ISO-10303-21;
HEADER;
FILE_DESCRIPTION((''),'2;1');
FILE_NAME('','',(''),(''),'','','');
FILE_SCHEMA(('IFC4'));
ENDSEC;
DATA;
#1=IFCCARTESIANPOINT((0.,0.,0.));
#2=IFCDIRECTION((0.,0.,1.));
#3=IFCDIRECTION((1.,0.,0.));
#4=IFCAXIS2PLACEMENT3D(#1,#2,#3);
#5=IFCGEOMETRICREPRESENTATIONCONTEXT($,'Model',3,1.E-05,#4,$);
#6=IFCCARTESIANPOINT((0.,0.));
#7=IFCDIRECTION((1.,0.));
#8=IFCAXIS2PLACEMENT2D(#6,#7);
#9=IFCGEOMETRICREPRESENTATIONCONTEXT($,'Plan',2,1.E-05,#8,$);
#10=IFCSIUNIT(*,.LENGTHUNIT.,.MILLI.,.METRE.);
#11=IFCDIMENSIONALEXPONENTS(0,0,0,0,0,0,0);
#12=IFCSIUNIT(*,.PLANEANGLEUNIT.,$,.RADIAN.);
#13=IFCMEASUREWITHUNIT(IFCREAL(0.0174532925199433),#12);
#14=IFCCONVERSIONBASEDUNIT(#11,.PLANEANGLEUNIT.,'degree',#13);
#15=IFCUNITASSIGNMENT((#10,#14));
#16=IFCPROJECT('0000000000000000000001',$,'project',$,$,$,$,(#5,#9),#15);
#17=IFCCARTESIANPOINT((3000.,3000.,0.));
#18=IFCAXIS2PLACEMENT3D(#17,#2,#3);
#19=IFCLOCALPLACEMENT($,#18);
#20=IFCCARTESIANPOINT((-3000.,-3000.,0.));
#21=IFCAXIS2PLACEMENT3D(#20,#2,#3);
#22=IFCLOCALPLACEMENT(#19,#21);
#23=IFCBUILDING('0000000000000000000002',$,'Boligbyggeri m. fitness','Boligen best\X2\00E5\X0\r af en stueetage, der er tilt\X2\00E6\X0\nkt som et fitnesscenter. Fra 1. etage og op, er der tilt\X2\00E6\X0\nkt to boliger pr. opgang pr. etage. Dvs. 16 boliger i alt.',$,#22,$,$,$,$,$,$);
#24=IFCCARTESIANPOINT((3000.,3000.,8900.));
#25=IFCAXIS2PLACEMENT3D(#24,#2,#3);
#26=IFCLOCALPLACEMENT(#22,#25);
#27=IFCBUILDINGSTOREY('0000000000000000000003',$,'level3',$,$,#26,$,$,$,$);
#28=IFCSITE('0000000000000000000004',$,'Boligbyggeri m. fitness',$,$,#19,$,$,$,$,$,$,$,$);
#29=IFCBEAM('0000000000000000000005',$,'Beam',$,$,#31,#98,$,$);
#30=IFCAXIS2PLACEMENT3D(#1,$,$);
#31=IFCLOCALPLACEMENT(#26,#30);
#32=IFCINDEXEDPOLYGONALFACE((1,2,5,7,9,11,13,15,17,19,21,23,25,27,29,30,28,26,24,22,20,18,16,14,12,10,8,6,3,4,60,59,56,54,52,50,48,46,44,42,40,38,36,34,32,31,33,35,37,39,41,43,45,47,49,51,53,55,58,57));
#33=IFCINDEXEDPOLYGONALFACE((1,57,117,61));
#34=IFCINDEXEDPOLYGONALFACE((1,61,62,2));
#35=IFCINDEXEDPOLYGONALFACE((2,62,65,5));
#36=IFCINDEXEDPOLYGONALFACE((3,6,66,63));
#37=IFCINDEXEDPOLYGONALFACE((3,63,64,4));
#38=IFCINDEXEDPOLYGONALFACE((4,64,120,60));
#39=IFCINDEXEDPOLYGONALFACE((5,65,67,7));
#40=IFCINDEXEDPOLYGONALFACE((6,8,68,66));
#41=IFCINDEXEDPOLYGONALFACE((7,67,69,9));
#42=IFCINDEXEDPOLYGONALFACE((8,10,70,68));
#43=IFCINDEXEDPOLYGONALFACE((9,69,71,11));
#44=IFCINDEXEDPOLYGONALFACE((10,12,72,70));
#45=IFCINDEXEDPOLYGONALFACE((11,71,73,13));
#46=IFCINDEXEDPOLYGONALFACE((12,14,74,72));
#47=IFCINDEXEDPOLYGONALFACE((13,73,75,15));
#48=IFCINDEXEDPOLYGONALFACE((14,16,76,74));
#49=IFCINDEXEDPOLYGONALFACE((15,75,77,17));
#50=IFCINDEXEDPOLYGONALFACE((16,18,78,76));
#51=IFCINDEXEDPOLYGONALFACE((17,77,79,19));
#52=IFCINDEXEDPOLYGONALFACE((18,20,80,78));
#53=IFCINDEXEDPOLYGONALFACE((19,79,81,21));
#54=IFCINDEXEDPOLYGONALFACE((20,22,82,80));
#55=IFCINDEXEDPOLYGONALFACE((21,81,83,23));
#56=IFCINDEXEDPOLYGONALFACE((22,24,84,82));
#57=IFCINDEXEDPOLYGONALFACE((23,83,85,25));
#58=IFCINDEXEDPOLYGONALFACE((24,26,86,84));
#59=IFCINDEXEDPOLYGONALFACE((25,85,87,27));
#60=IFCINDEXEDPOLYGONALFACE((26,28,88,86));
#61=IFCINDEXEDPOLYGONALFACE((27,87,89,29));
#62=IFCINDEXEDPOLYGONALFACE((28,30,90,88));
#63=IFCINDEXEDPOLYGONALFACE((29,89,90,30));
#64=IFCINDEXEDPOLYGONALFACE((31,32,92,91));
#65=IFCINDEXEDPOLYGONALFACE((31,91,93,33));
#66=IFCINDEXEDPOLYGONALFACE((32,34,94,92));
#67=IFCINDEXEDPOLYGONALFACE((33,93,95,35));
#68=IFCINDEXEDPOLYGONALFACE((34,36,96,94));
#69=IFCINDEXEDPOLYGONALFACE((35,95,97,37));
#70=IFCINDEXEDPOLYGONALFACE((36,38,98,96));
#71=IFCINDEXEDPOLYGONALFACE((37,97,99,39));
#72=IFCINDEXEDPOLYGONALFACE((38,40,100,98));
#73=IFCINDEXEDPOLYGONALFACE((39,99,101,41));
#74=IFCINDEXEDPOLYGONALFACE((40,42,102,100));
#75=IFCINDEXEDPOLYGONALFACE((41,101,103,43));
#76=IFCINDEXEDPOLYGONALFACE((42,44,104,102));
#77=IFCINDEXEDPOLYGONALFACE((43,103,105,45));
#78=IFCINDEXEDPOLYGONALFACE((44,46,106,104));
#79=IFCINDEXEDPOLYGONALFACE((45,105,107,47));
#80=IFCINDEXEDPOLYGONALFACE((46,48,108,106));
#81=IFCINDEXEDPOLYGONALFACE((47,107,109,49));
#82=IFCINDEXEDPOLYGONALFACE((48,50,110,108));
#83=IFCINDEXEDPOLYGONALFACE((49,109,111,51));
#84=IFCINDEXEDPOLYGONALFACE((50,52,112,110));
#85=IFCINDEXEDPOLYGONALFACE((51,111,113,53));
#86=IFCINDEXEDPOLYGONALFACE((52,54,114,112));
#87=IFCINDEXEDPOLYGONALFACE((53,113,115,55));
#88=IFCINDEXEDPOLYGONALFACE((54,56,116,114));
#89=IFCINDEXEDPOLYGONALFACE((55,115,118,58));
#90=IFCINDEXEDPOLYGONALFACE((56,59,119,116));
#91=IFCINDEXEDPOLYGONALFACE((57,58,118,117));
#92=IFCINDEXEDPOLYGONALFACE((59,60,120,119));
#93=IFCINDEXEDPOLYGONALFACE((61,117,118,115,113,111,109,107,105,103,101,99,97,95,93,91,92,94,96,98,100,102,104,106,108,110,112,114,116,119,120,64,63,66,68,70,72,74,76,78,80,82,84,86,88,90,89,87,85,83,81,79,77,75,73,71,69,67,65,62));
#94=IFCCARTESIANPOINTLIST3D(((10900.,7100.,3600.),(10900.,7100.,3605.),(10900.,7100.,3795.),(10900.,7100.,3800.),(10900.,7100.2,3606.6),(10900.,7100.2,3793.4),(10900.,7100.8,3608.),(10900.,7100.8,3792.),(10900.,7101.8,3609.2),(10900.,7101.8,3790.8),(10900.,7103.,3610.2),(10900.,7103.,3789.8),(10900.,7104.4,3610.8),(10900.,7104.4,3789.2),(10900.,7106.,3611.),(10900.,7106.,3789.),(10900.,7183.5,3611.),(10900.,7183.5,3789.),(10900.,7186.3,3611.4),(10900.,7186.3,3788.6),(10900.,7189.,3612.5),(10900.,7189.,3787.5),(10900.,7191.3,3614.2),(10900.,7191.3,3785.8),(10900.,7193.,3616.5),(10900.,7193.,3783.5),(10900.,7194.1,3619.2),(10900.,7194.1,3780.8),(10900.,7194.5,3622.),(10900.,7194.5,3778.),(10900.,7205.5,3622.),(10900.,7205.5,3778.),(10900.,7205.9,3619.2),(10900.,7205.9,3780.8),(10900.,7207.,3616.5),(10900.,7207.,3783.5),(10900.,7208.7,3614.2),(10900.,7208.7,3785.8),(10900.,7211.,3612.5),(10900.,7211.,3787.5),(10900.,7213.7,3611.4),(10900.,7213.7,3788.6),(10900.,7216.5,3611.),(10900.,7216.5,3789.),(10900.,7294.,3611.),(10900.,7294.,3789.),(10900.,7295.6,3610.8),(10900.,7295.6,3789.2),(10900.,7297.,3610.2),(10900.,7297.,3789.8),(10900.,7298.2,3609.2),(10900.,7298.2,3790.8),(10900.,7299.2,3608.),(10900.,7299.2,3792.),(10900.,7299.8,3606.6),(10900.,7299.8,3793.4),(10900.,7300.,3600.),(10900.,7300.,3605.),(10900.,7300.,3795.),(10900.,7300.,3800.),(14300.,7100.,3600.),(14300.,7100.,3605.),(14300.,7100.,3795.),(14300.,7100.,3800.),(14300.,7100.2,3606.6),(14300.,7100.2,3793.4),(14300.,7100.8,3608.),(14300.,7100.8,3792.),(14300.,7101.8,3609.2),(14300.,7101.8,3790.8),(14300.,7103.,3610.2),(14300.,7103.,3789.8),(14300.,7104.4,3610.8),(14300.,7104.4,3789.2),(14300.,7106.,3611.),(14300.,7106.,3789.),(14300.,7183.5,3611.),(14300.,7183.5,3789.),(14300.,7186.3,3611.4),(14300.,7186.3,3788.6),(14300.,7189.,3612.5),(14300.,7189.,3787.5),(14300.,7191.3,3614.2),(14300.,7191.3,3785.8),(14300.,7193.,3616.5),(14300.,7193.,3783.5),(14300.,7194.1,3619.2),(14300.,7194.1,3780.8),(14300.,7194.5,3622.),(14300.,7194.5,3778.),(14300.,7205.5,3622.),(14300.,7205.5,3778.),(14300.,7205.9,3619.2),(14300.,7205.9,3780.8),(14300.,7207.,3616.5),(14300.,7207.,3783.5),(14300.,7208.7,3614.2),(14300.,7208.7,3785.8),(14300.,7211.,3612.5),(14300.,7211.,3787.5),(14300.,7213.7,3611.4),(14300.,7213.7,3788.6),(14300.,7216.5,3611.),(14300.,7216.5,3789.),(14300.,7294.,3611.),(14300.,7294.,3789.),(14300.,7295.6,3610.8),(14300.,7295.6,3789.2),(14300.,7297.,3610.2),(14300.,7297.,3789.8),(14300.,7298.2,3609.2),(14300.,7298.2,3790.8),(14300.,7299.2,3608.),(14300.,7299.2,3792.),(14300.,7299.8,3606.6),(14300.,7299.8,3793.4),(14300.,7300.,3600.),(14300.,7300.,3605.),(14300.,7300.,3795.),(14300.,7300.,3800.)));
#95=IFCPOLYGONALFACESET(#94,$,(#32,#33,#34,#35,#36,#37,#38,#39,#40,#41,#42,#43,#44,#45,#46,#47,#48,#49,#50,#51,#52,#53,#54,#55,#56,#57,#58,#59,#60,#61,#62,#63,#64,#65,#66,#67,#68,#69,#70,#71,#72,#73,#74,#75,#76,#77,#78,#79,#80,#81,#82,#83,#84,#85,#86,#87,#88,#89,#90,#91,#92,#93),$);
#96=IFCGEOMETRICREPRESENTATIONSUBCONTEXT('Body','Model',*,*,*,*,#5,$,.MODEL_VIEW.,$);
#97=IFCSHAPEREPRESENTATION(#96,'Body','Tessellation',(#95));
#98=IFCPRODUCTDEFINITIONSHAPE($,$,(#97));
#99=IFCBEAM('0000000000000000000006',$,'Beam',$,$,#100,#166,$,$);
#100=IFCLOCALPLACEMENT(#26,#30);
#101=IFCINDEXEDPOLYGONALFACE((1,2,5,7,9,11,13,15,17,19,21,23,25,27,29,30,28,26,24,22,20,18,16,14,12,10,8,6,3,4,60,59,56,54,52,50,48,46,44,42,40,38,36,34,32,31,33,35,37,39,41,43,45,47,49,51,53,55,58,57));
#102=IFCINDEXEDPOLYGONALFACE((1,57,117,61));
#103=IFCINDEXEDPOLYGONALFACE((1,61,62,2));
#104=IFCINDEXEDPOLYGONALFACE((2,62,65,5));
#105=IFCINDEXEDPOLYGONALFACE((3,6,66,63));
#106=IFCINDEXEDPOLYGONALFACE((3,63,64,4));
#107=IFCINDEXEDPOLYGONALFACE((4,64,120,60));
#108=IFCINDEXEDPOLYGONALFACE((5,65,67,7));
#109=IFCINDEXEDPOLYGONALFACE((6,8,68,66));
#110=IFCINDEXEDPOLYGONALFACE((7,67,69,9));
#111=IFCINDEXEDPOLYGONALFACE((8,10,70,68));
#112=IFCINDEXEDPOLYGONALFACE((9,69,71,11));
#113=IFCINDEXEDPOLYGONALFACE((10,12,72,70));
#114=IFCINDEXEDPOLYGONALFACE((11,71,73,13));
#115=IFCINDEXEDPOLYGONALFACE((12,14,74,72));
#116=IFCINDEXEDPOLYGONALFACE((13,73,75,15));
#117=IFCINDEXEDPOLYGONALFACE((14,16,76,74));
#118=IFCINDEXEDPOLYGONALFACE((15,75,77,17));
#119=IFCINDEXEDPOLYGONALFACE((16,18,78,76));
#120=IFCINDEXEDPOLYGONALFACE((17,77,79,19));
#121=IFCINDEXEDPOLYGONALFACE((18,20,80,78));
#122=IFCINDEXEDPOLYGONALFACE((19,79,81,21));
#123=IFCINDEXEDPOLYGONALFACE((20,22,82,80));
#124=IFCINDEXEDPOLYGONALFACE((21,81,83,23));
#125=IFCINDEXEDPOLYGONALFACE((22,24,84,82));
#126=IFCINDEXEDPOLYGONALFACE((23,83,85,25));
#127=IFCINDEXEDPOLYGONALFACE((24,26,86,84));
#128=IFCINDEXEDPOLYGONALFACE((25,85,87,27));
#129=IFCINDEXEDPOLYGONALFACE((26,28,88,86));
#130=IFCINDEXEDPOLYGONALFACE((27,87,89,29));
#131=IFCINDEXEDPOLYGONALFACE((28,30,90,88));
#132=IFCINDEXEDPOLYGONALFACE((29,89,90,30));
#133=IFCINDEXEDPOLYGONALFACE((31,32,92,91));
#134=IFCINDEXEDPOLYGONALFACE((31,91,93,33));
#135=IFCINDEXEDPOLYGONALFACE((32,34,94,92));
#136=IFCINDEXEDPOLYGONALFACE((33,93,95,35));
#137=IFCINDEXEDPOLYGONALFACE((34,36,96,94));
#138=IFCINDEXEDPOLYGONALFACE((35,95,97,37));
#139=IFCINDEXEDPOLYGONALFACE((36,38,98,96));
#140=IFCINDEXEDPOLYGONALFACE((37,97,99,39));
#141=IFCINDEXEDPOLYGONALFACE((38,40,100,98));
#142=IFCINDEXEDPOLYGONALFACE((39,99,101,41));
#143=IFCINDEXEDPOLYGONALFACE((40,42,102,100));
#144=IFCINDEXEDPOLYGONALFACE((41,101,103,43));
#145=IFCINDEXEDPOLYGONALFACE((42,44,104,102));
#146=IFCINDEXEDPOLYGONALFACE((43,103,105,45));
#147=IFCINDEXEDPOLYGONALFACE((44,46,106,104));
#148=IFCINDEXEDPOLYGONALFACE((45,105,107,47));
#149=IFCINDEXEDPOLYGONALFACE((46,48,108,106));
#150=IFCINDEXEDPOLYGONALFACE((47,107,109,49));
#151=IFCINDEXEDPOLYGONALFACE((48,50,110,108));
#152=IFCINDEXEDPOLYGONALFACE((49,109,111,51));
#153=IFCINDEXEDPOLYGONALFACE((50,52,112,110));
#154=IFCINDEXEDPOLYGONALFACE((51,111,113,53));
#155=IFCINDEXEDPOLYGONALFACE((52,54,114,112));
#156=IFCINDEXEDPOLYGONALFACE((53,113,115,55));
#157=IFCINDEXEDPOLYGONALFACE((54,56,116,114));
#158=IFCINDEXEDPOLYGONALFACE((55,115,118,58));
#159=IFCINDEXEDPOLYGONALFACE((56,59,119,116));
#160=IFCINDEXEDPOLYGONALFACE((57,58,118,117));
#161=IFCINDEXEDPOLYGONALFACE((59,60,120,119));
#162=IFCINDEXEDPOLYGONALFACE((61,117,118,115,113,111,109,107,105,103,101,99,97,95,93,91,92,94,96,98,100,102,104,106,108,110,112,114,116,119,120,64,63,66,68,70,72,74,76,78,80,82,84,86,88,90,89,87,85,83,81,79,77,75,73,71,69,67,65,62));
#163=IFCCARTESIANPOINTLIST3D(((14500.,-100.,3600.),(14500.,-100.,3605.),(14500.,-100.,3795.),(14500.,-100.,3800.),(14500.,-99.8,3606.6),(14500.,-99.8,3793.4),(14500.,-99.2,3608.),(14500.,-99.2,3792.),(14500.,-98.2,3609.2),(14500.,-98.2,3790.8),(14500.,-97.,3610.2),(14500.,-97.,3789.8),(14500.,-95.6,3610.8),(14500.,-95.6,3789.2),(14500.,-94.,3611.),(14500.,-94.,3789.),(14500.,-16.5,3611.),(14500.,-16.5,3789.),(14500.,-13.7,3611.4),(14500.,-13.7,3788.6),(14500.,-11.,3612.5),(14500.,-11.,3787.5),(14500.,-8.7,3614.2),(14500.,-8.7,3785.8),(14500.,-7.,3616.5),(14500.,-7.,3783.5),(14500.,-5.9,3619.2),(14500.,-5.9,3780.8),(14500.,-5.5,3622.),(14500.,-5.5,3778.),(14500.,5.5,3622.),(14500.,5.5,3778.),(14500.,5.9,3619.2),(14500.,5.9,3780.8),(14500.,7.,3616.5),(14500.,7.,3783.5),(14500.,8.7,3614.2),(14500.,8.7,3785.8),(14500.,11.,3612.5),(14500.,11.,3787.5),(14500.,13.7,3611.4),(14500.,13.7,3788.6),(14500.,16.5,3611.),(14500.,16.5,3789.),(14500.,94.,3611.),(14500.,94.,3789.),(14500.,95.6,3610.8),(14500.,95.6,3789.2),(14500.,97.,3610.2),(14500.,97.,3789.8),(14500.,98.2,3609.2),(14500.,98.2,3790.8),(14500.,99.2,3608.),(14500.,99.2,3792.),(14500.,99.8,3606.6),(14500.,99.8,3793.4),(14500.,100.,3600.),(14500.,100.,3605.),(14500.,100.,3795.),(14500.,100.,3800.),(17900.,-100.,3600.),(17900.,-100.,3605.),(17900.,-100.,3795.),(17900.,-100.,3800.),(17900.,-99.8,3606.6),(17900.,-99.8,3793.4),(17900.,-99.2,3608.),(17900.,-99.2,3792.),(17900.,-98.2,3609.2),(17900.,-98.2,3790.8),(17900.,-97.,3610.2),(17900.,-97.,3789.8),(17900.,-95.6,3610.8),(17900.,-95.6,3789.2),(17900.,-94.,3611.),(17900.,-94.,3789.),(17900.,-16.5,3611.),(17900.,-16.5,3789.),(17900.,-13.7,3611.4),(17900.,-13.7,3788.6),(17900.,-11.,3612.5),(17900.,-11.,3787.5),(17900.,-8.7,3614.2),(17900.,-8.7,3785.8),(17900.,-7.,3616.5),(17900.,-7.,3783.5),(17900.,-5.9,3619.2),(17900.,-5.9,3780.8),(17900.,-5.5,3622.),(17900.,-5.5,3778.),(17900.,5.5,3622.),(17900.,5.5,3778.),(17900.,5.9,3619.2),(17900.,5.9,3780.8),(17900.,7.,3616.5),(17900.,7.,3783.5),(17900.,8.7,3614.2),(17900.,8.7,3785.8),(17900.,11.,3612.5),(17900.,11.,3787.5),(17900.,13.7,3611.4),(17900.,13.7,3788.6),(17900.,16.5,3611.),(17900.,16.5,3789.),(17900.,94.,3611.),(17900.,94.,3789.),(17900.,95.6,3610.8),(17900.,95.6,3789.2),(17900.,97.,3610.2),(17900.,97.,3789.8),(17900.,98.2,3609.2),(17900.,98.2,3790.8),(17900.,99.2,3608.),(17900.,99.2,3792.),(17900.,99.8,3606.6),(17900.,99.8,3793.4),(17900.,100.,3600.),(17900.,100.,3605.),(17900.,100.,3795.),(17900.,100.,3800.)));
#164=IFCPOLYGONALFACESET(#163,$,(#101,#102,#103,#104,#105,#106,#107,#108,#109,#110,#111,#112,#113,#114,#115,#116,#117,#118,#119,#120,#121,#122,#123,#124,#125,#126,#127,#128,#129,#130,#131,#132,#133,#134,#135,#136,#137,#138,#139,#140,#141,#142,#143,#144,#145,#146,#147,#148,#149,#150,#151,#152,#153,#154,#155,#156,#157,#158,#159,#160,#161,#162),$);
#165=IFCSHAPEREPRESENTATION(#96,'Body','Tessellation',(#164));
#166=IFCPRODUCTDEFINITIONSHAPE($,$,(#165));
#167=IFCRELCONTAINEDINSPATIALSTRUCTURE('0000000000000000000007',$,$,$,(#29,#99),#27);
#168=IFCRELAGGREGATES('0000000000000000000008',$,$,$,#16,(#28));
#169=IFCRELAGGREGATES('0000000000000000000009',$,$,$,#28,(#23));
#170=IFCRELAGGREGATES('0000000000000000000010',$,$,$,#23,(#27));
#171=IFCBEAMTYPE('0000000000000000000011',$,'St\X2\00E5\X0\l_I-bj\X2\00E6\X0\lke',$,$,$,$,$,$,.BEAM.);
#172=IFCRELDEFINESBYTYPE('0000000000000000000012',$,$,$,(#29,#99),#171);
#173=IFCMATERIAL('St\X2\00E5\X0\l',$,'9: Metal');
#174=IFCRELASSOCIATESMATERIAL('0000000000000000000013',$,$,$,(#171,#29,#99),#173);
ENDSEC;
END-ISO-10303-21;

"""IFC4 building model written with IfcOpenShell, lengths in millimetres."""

from ifc_helpers import new_model, entity, si_unit, converted_unit, frame, origin_with_axes, origin_2d_with_axis, place, context, subcontext, project, spatial, i_section, extrude, material, material_profile, profile_set, profile_usage, type_object, element, save


model = new_model("IFC4")

# Units and contexts
model_context = context("Model", 3, precision=1e-05, world=origin_with_axes())
plan_context = context("Plan", 2, precision=1e-05, world=origin_2d_with_axis())
body_context = subcontext(model_context, "Body", "Model", "MODEL_VIEW")
ifc_project = project(units=[si_unit("LENGTHUNIT", "METRE", prefix="MILLI"), converted_unit("PLANEANGLEUNIT", "degree", entity("IfcReal", 0.0174532925199433), si_unit("PLANEANGLEUNIT", "RADIAN"), dimensions=[0, 0, 0, 0, 0, 0, 0])], contexts=[model_context, plan_context])

# Site, building, storey
site_placement = place(None, frame((3000.0, 3000.0, 0.0), z_axis=(0.0, 0.0, 1.0), x_axis=(1.0, 0.0, 0.0)))
site = spatial("IfcSite", under=ifc_project, at=site_placement, Name="Boligbyggeri m. fitness")
building_placement = place(site_placement, frame((-3000.0, -3000.0, 0.0), z_axis=(0.0, 0.0, 1.0), x_axis=(1.0, 0.0, 0.0)))
building = spatial("IfcBuilding", under=site, at=building_placement, Name="Boligbyggeri m. fitness", Description="Boligen består af en stueetage, der er tiltænkt som et fitnesscenter. Fra 1. etage og op, er der tiltænkt to boliger pr. opgang pr. etage. Dvs. 16 boliger i alt.")
storey_placement = place(building_placement, frame((3000.0, 3000.0, 8900.0), z_axis=(0.0, 0.0, 1.0), x_axis=(1.0, 0.0, 0.0)))
storey = spatial("IfcBuildingStorey", under=building, at=storey_placement, Name="level3")

# Beams
ifc_material_1 = material(Name="Stål", Category="9: Metal")
ifc_material_profile_1 = material_profile(ifc_material_1, i_section(OverallWidth=200.0, OverallDepth=200.0, WebThickness=11.0, FlangeThickness=11.0, FilletRadius=11.0, FlangeEdgeRadius=6.0), Name="Stål", Category="9: Metal")
ifc_profile_set_1 = profile_set([ifc_material_profile_1], Name="NY_I-Profil")
beam_type = type_object("IfcBeamType", Name="Stål_I-bjælke", PredefinedType="BEAM", material=ifc_profile_set_1)
ifc_profile_usage_1 = profile_usage(ifc_profile_set_1, cardinal=7)
beam_1_placement = place(storey_placement, frame((10900.0, 7300.0, 3800.0), z_axis=(1.0, 0.0, 0.0), x_axis=(0.0, 1.0, 0.0)))
element("IfcBeam", 1, at=beam_1_placement, inside=storey, type_object=beam_type, material=ifc_profile_usage_1, Name="Beam", context=body_context, shape_type="SweptSolid", body=[
    extrude(i_section(OverallWidth=200.0, OverallDepth=200.0, WebThickness=11.0, FlangeThickness=11.0, FilletRadius=11.0, FlangeEdgeRadius=6.0), frame((-100.0, -100.0, 0.0), z_axis=(0.0, 0.0, 1.0), x_axis=(1.0, 0.0, 0.0)), (0.0, 0.0, 1.0), 3400.0),
])
ifc_profile_usage_2 = profile_usage(ifc_profile_set_1, cardinal=7)
beam_2_placement = place(storey_placement, frame((14500.0, 100.0, 3800.0), z_axis=(1.0, 0.0, 0.0), x_axis=(0.0, 1.0, 0.0)))
element("IfcBeam", 2, at=beam_2_placement, inside=storey, type_object=beam_type, material=ifc_profile_usage_2, Name="Beam", context=body_context, shape_type="SweptSolid", body=[
    extrude(i_section(OverallWidth=200.0, OverallDepth=200.0, WebThickness=11.0, FlangeThickness=11.0, FilletRadius=11.0, FlangeEdgeRadius=6.0), frame((-100.0, -100.0, 0.0), z_axis=(0.0, 0.0, 1.0), x_axis=(1.0, 0.0, 0.0)), (0.0, 0.0, 1.0), 3400.0),
])

save(model, "model.ifc")
